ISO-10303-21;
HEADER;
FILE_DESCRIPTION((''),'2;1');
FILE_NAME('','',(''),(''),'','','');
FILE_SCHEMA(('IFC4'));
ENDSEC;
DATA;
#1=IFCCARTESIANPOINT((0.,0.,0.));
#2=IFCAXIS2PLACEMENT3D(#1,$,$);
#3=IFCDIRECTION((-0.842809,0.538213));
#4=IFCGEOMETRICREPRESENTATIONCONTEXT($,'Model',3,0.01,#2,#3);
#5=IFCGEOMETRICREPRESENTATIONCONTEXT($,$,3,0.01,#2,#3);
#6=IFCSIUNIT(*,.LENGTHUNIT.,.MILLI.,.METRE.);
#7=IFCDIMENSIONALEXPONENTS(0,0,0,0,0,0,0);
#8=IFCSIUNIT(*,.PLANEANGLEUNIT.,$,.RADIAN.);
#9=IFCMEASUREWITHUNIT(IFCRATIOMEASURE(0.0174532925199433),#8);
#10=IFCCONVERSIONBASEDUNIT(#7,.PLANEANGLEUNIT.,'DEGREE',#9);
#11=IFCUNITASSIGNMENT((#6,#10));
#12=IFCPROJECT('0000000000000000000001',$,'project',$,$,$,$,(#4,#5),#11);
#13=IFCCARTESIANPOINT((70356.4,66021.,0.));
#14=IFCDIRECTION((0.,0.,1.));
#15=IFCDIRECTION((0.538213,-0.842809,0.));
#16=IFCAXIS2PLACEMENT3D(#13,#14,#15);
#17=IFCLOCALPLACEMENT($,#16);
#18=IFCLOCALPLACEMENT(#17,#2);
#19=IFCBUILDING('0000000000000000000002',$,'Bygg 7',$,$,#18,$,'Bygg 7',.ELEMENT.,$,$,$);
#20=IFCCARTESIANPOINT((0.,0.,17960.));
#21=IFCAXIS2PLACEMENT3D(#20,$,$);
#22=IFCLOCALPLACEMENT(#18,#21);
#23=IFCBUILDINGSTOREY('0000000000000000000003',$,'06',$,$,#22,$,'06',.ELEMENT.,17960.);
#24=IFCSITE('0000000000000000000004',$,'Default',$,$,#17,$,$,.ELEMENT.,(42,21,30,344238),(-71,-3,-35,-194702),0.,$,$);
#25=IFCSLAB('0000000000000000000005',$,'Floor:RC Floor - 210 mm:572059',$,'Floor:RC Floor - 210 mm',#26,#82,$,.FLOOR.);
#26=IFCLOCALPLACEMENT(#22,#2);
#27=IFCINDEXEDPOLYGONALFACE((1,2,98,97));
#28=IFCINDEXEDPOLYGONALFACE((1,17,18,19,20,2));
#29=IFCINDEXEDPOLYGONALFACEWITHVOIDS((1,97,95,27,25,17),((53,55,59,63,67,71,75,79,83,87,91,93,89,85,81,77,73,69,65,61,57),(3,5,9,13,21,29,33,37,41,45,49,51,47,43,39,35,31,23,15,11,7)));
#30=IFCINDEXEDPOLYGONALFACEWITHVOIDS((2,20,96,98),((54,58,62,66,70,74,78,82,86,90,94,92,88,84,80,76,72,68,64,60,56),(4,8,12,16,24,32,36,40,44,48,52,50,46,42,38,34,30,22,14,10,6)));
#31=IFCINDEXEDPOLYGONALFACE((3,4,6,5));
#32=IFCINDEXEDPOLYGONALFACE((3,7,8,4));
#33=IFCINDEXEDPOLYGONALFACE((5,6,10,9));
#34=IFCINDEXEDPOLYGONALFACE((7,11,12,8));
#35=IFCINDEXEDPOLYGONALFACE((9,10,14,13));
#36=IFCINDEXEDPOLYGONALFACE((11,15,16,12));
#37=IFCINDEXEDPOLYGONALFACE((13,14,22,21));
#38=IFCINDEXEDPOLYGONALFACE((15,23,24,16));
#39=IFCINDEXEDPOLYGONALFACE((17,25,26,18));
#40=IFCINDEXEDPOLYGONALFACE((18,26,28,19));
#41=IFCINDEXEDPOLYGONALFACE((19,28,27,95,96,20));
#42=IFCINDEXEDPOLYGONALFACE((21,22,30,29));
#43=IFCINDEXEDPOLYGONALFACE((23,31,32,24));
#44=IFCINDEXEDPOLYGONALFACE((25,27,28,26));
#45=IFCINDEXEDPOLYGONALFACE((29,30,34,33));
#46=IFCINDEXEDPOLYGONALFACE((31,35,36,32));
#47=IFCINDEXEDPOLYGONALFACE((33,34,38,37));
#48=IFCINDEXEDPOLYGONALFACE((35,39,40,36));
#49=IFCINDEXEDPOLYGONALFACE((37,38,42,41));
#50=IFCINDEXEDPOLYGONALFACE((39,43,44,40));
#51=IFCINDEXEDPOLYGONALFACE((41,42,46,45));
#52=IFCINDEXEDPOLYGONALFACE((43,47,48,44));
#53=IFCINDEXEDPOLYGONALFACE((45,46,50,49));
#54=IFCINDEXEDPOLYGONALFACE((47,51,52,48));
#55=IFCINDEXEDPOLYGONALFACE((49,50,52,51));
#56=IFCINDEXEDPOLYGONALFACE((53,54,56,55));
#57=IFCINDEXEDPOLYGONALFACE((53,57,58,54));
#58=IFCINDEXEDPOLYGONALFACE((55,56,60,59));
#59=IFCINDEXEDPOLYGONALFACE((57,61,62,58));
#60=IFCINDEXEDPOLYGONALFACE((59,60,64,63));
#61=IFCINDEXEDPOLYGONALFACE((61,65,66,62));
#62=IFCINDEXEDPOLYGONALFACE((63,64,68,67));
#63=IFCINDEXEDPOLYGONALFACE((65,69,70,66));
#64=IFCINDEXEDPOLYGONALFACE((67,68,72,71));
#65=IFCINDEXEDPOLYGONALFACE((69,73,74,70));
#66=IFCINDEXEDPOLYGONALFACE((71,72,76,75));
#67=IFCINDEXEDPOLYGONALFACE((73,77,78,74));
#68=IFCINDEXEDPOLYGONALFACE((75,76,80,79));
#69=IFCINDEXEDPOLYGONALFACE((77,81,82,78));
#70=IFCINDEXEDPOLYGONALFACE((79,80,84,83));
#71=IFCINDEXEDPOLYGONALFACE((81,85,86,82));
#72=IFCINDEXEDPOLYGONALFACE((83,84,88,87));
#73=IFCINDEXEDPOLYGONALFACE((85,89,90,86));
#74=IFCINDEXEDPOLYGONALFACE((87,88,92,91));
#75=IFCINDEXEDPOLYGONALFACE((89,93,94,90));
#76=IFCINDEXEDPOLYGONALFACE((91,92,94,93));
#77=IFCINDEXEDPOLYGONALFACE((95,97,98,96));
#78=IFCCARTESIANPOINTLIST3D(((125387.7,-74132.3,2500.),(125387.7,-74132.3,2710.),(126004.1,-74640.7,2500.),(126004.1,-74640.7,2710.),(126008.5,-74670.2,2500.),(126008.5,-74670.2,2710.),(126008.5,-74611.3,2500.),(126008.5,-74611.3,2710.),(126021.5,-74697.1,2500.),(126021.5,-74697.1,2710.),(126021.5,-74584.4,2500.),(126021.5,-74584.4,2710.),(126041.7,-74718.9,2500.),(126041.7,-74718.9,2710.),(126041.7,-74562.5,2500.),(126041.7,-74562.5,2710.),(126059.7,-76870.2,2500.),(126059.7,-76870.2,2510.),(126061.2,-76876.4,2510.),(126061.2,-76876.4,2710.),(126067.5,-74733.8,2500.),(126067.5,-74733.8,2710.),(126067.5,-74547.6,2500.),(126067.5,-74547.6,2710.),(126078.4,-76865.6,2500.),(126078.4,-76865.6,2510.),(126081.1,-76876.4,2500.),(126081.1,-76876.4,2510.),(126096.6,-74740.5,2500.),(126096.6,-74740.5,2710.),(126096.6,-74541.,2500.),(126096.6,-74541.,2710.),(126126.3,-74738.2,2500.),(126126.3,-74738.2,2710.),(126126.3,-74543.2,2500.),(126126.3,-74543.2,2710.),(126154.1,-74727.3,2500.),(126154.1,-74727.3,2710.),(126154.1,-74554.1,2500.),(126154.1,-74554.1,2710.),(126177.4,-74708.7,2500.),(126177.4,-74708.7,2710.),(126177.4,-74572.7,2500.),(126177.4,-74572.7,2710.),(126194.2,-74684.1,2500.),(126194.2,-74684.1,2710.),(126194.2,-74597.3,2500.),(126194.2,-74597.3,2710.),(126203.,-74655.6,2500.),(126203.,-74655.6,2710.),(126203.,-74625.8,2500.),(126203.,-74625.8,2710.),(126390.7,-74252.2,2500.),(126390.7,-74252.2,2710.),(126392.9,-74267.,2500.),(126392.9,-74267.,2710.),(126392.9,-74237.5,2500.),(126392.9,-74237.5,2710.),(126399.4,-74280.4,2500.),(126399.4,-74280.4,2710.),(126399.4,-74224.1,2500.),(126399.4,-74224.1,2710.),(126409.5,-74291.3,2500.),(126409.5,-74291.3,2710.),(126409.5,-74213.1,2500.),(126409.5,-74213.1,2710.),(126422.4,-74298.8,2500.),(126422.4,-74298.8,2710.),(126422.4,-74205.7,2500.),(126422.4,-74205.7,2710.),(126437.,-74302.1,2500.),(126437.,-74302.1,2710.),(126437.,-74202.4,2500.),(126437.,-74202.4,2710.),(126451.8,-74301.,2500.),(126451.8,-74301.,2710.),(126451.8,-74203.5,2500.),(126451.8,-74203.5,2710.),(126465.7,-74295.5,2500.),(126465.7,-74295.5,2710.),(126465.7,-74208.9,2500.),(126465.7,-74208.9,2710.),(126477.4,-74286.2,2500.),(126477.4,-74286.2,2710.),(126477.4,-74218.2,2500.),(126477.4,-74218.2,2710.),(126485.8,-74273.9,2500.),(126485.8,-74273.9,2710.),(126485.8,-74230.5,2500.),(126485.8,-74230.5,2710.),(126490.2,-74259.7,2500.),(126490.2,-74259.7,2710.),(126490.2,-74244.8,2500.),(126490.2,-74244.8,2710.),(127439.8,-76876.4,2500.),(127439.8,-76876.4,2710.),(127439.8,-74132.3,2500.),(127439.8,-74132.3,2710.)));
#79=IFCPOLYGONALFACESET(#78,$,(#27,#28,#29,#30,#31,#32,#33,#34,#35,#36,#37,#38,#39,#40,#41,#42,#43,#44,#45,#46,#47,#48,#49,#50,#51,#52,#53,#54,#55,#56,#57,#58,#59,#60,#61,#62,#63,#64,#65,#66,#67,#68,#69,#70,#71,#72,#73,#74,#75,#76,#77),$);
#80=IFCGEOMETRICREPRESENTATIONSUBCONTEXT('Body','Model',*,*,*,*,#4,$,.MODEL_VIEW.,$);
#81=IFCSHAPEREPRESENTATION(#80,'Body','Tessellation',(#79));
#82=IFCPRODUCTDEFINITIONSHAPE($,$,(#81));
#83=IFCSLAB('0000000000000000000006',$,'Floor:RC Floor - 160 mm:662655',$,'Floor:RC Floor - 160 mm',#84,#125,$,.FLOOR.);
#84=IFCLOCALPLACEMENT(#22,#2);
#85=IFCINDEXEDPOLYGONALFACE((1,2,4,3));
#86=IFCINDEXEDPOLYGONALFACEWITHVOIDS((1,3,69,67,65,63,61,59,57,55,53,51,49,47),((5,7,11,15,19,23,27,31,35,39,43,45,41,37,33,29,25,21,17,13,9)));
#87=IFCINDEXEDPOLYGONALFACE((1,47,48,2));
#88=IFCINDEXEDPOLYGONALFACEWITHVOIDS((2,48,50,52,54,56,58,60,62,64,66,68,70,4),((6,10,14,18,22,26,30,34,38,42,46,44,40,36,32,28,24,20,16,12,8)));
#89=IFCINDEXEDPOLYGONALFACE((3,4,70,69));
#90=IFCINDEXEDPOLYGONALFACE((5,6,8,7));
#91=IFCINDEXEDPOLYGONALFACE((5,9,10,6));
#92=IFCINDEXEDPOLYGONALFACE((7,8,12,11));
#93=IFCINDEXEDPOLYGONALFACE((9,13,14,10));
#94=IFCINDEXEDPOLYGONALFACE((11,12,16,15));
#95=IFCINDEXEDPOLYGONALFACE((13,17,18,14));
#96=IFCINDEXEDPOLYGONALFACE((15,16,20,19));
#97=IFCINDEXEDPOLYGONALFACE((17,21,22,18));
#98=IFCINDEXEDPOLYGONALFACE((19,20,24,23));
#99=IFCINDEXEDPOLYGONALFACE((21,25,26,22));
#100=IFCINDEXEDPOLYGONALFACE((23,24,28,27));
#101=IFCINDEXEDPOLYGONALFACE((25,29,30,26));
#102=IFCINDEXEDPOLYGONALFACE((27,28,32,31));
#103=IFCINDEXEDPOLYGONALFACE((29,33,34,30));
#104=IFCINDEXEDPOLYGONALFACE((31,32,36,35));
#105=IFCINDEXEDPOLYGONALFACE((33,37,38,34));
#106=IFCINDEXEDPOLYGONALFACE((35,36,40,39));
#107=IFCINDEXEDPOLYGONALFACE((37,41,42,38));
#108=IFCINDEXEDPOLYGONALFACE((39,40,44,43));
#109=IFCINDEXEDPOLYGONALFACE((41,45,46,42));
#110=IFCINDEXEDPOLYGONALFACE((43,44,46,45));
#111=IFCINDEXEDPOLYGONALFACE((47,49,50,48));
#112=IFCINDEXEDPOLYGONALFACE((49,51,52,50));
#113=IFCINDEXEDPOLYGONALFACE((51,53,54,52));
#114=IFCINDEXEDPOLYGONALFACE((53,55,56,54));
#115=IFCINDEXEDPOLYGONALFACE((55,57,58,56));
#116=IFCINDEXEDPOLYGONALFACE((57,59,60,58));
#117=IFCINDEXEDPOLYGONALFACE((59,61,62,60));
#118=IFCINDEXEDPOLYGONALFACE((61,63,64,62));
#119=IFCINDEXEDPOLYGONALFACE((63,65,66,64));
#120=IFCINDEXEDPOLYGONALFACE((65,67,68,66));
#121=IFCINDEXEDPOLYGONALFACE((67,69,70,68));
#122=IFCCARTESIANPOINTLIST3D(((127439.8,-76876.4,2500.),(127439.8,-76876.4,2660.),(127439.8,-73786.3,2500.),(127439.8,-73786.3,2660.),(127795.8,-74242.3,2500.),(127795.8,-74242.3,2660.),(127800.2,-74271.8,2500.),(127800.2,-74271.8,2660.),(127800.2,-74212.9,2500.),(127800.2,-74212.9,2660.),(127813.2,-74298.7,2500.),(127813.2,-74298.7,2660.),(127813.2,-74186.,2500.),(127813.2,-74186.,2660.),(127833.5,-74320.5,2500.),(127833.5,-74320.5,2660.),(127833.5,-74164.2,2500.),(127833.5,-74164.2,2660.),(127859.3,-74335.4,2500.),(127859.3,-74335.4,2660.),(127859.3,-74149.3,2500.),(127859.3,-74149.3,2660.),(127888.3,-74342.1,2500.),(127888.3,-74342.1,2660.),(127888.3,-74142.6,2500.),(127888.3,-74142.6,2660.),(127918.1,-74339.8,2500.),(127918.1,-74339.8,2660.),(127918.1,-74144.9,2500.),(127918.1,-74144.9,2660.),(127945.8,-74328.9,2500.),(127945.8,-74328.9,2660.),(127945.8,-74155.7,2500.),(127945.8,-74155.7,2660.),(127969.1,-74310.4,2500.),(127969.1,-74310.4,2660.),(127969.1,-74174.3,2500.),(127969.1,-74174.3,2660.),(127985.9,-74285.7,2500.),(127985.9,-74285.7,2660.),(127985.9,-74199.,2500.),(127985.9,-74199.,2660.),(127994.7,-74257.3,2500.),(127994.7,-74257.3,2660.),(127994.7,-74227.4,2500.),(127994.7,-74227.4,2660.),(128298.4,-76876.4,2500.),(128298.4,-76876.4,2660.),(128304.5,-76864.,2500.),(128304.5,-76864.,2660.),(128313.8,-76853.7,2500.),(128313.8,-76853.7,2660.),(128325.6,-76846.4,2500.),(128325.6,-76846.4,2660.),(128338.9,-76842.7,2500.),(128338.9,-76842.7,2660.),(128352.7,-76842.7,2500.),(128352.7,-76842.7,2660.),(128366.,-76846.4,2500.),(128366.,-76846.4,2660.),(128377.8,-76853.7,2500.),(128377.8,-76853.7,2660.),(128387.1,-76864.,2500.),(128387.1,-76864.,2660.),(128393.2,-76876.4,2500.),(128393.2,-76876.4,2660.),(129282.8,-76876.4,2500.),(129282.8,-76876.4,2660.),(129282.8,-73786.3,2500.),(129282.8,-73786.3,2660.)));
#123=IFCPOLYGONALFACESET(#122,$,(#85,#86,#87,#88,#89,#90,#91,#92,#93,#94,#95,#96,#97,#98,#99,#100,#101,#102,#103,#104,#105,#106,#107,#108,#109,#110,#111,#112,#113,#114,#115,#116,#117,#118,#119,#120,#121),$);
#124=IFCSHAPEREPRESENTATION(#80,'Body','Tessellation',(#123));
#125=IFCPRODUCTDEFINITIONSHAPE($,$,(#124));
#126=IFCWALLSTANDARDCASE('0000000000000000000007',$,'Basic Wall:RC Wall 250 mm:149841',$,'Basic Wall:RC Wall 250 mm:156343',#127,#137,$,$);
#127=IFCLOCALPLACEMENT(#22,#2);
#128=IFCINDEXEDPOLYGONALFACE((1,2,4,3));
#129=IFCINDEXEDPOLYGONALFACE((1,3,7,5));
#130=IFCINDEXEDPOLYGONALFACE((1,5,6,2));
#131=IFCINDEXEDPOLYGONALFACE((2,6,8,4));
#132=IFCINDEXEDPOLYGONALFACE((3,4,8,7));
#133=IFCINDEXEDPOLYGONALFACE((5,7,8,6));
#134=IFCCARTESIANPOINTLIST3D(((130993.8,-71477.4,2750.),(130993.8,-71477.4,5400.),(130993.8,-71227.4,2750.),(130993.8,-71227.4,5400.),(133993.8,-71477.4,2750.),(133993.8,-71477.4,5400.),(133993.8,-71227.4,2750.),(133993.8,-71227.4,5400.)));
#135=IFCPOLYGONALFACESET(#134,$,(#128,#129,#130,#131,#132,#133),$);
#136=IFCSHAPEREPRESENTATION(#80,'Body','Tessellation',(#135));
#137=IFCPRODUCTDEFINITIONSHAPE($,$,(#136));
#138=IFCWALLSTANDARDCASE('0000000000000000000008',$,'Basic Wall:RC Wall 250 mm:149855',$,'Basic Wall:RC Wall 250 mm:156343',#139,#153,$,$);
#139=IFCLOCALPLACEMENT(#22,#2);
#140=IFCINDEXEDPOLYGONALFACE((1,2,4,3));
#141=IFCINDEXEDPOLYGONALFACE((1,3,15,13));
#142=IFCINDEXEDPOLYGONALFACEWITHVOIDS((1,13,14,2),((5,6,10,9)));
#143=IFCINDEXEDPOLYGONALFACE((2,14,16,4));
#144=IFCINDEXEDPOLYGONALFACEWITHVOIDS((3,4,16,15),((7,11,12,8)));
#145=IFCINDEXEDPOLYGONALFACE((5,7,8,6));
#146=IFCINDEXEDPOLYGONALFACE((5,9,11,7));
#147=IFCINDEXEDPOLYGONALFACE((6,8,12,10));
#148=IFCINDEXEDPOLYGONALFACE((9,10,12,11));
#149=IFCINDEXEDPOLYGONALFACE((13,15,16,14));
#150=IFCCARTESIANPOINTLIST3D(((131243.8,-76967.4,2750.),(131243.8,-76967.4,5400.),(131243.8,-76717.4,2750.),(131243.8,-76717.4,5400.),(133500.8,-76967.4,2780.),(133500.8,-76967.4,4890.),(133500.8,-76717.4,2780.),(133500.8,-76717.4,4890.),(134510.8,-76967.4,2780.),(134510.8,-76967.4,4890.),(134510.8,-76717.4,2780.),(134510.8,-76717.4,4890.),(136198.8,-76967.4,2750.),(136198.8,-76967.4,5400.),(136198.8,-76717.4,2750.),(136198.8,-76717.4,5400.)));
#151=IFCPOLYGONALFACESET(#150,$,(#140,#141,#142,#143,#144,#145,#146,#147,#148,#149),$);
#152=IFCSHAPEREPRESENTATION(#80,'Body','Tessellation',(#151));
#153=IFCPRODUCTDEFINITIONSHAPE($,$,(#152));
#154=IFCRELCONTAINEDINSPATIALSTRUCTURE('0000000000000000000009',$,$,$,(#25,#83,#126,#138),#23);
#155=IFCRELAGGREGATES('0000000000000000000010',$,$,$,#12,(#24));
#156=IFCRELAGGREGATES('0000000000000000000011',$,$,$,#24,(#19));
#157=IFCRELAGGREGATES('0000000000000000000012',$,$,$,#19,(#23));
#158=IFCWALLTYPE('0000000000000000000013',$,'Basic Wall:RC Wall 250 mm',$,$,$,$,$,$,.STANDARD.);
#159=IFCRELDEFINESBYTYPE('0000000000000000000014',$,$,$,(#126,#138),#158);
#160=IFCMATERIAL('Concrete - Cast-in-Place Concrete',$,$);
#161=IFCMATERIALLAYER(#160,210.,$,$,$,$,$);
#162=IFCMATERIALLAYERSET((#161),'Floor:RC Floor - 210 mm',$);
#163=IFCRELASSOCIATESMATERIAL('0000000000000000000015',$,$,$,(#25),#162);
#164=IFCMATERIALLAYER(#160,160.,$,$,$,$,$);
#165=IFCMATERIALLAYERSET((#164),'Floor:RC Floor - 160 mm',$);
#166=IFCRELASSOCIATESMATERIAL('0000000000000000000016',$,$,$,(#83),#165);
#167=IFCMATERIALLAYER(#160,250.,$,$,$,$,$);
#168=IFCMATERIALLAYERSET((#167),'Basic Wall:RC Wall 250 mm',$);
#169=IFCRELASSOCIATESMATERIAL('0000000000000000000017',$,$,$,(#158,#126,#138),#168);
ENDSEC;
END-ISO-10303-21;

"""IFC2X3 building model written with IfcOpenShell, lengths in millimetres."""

from ifc_helpers import new_model, entity, si_unit, converted_unit, direction, frame, frame_2d, origin, origin_2d_with_axis, place, context, subcontext, project, spatial, polyline, rectangle, circle, outline, extrude, clip, bounded_halfspace, material, layer, layer_set, layer_usage, type_object, element, save


model = new_model("IFC2X3")

# Units and contexts
model_context = context("Model", 3, precision=0.01, world=origin(), true_north=direction((-0.842809, 0.538213)))
context_of_model = context(None, 3, precision=0.01, world=origin(), true_north=direction((-0.842809, 0.538213)))
body_context = subcontext(model_context, "Body", "Model", "MODEL_VIEW")
ifc_project = project(units=[si_unit("LENGTHUNIT", "METRE", prefix="MILLI"), converted_unit("PLANEANGLEUNIT", "DEGREE", entity("IfcRatioMeasure", 0.0174532925199433), si_unit("PLANEANGLEUNIT", "RADIAN"), dimensions=[0, 0, 0, 0, 0, 0, 0])], contexts=[model_context, context_of_model])

# Site, building, storey
site_placement = place(None, frame((70356.4, 66021.0, 0.0), z_axis=(0.0, 0.0, 1.0), x_axis=(0.538213, -0.842809, 0.0)))
site = spatial("IfcSite", under=ifc_project, at=site_placement, Name="Default", CompositionType="ELEMENT", RefLatitude=(42, 21, 30, 344238), RefLongitude=(-71, -3, -35, -194702), RefElevation=0.0)
building_placement = place(site_placement, origin())
building = spatial("IfcBuilding", under=site, at=building_placement, Name="Bygg 7", LongName="Bygg 7", CompositionType="ELEMENT")
storey_placement = place(building_placement, frame((0.0, 0.0, 17960.0)))
storey = spatial("IfcBuildingStorey", under=building, at=storey_placement, Name="06", LongName="06", CompositionType="ELEMENT", Elevation=17960.0)

# Shared definitions
ifc_material_1 = material(Name="Concrete - Cast-in-Place Concrete")
ifc_layer_1 = layer(ifc_material_1, 160.0)
ifc_layer_set_1 = layer_set([ifc_layer_1], Name="Floor:RC Floor - 160 mm")

# Slabs, openings
ifc_layer_2 = layer(ifc_material_1, 210.0)
ifc_layer_set_2 = layer_set([ifc_layer_2], Name="Floor:RC Floor - 210 mm")
ifc_layer_usage_1 = layer_usage(ifc_layer_set_2, "AXIS3", "POSITIVE", 0.0)
slab_1_placement = place(storey_placement, frame((125387.7, -76876.4, 2500.0)))
slab_1 = element("IfcSlab", 1, at=slab_1_placement, inside=storey, material=ifc_layer_usage_1, Name="Floor:RC Floor - 210 mm:572059", ObjectType="Floor:RC Floor - 210 mm", PredefinedType="FLOOR", context=body_context, shape_type="SweptSolid", body=[
    extrude(outline(polyline([(-1026.1, 1372.0), (-1026.1, -1372.0), (352.5, -1372.0), (1026.1, 1372.0), (-1026.1, 1372.0)])), frame((1026.1, 1372.0, 210.0), z_axis=(0.0, 0.0, -1.0), x_axis=(-1.0, 0.0, 0.0)), (0.0, 0.0, 1.0), 210.0),
])
opening_1_placement = place(storey_placement, frame((125387.7, -76876.4, 2500.0)))
element("IfcOpeningElement", 2, at=opening_1_placement, cuts=slab_1, ObjectType="Opening", context=body_context, shape_type="SweptSolid", body=[
    extrude(circle(Radius=100.0, at=frame_2d((309.7, 863.6), x_axis=(1.0, 0.0))), frame((1026.1, 1372.0, 210.0), z_axis=(0.0, 0.0, -1.0), x_axis=(-1.0, 0.0, 0.0)), (0.0, 0.0, 1.0), 210.0),
])
opening_2_placement = place(storey_placement, frame((125387.7, -76876.4, 2500.0)))
element("IfcOpeningElement", 3, at=opening_2_placement, cuts=slab_1, ObjectType="Opening", context=body_context, shape_type="SweptSolid", body=[
    extrude(circle(Radius=50.0, at=frame_2d((-26.9, 1252.1), x_axis=(1.0, 0.0))), frame((1026.1, 1372.0, 210.0), z_axis=(0.0, 0.0, -1.0), x_axis=(-1.0, 0.0, 0.0)), (0.0, 0.0, 1.0), 210.0),
])
opening_3_placement = place(slab_1_placement, origin())
element("IfcOpeningElement", 4, at=opening_3_placement, cuts=slab_1, ObjectType="Opening", context=body_context, shape_type="SweptSolid", body=[
    extrude(rectangle(XDim=200.0, YDim=200.0, at=origin_2d_with_axis()), frame((617.5, -110.2, 240.0), z_axis=(0.0, 0.0, 1.0), x_axis=(-0.971172, -0.238381, 0.0)), (0.0, 0.0, 1.0), 10.0),
])
opening_4_placement = place(slab_1_placement, origin())
element("IfcOpeningElement", 5, at=opening_4_placement, cuts=slab_1, ObjectType="Opening", context=body_context, shape_type="SweptSolid", body=[
    extrude(rectangle(XDim=200.0, YDim=200.0, at=origin_2d_with_axis()), frame((617.5, -110.2, 0.0), z_axis=(0.0, 0.0, 1.0), x_axis=(-0.971172, -0.238381, 0.0)), (0.0, 0.0, 1.0), 10.0),
])
ifc_layer_usage_2 = layer_usage(ifc_layer_set_1, "AXIS3", "POSITIVE", 0.0)
slab_2_placement = place(storey_placement, frame((127439.8, -76876.4, 2500.0)))
slab_2 = element("IfcSlab", 6, at=slab_2_placement, inside=storey, material=ifc_layer_usage_2, Name="Floor:RC Floor - 160 mm:662655", ObjectType="Floor:RC Floor - 160 mm", PredefinedType="FLOOR", context=body_context, shape_type="SweptSolid", body=[
    extrude(rectangle(XDim=3090.1, YDim=1843.0, at=frame_2d((0.0, 0.0), x_axis=(0.0, 1.0))), frame((921.5, 1545.0, 160.0), z_axis=(0.0, 0.0, -1.0), x_axis=(-1.0, 0.0, 0.0)), (0.0, 0.0, 1.0), 160.0),
])
opening_5_placement = place(storey_placement, frame((127439.8, -76876.4, 2500.0)))
element("IfcOpeningElement", 7, at=opening_5_placement, cuts=slab_2, ObjectType="Opening", context=body_context, shape_type="SweptSolid", body=[
    extrude(circle(Radius=100.0, at=frame_2d((465.5, 1089.0), x_axis=(1.0, 0.0))), frame((921.5, 1545.0, 160.0), z_axis=(0.0, 0.0, -1.0), x_axis=(-1.0, 0.0, 0.0)), (0.0, 0.0, 1.0), 160.0),
])
opening_6_placement = place(storey_placement, frame((127439.8, -76876.4, 2500.0)))
element("IfcOpeningElement", 8, at=opening_6_placement, cuts=slab_2, ObjectType="Opening", context=body_context, shape_type="SweptSolid", body=[
    extrude(circle(Radius=50.0, at=frame_2d((15.5, -1560.8), x_axis=(1.0, 0.0))), frame((921.5, 1545.0, 160.0), z_axis=(0.0, 0.0, -1.0), x_axis=(-1.0, 0.0, 0.0)), (0.0, 0.0, 1.0), 160.0),
])

# Wall
ifc_layer_3 = layer(ifc_material_1, 250.0)
ifc_layer_set_3 = layer_set([ifc_layer_3], Name="Basic Wall:RC Wall 250 mm")
ifc_layer_usage_3 = layer_usage(ifc_layer_set_3, "AXIS2", "NEGATIVE", 125.0)
wall_type_1 = type_object("IfcWallType", Name="Basic Wall:RC Wall 250 mm", PredefinedType="STANDARD", material=ifc_layer_set_3)
wall_1_placement = place(storey_placement, frame((130993.8, -71352.4, 2750.0)))
element("IfcWallStandardCase", 9, at=wall_1_placement, inside=storey, type_object=wall_type_1, material=ifc_layer_usage_3, Name="Basic Wall:RC Wall 250 mm:149841", ObjectType="Basic Wall:RC Wall 250 mm:156343", context=body_context, shape_type="Clipping", body=[
    clip(clip(extrude(rectangle(XDim=3000.0, YDim=250.0, at=frame_2d((1500.0, 0.0), x_axis=(-1.0, 0.0))), origin(), (0.0, 0.0, 1.0), 2650.0), bounded_halfspace(frame((3000.0, -125.0, 0.0), z_axis=(0.0, 0.0, 1.0), x_axis=(-0.092529, 0.99571, 0.0)), True, frame((3000.0, -125.0, 0.0)), polyline([(0.0, 0.0), (0.0, 250.0), (-3000.0, 250.0), (-3000.0, 0.0), (-2750.0, 0.0), (0.0, 0.0)]))), bounded_halfspace(frame((0.0, -125.0, 2650.0), z_axis=(0.0, 0.0, -1.0), x_axis=(-1.0, 0.0, 0.0)), True, frame((0.0, -125.0, 2650.0)), polyline([(0.0, 0.0), (250.0, 0.0), (3000.0, 0.0), (3000.0, 250.0), (0.0, 250.0), (0.0, 0.0)]))),
])

# Wall, opening
ifc_layer_usage_4 = layer_usage(ifc_layer_set_3, "AXIS2", "NEGATIVE", 125.0)
wall_2_placement = place(storey_placement, frame((131243.8, -76842.4, 2750.0)))
wall_2 = element("IfcWallStandardCase", 10, at=wall_2_placement, inside=storey, type_object=wall_type_1, material=ifc_layer_usage_4, Name="Basic Wall:RC Wall 250 mm:149855", ObjectType="Basic Wall:RC Wall 250 mm:156343", context=body_context, shape_type="Clipping", body=[
    clip(clip(extrude(rectangle(XDim=4955.0, YDim=250.0, at=frame_2d((2477.5, 0.0), x_axis=(-1.0, 0.0))), origin(), (0.0, 0.0, 1.0), 2650.0), bounded_halfspace(frame((4955.0, -125.0, 0.0), z_axis=(0.0, 0.0, 1.0), x_axis=(-0.092529, 0.99571, 0.0)), True, frame((4955.0, -125.0, 0.0)), polyline([(0.0, 0.0), (0.0, 250.0), (-250.0, 250.0), (-4955.0, 250.0), (-4955.0, 0.0), (0.0, 0.0)]))), bounded_halfspace(frame((0.0, -125.0, 2650.0), z_axis=(0.0, 0.0, -1.0), x_axis=(-1.0, 0.0, 0.0)), True, frame((0.0, -125.0, 2650.0)), polyline([(0.0, 0.0), (4955.0, 0.0), (4955.0, 250.0), (4705.0, 250.0), (0.0, 250.0), (0.0, 0.0)]))),
])
opening_7_placement = place(wall_2_placement, origin())
element("IfcOpeningElement", 11, at=opening_7_placement, cuts=wall_2, ObjectType="Opening", context=body_context, shape_type="SweptSolid", body=[
    extrude(rectangle(XDim=2110.0, YDim=1010.0, at=origin_2d_with_axis()), frame((2762.0, -125.0, 1085.0), z_axis=(0.0, 1.0, 0.0), x_axis=(0.0, 0.0, -1.0)), (0.0, 0.0, 1.0), 250.0),
])

save(model, "model.ifc")
